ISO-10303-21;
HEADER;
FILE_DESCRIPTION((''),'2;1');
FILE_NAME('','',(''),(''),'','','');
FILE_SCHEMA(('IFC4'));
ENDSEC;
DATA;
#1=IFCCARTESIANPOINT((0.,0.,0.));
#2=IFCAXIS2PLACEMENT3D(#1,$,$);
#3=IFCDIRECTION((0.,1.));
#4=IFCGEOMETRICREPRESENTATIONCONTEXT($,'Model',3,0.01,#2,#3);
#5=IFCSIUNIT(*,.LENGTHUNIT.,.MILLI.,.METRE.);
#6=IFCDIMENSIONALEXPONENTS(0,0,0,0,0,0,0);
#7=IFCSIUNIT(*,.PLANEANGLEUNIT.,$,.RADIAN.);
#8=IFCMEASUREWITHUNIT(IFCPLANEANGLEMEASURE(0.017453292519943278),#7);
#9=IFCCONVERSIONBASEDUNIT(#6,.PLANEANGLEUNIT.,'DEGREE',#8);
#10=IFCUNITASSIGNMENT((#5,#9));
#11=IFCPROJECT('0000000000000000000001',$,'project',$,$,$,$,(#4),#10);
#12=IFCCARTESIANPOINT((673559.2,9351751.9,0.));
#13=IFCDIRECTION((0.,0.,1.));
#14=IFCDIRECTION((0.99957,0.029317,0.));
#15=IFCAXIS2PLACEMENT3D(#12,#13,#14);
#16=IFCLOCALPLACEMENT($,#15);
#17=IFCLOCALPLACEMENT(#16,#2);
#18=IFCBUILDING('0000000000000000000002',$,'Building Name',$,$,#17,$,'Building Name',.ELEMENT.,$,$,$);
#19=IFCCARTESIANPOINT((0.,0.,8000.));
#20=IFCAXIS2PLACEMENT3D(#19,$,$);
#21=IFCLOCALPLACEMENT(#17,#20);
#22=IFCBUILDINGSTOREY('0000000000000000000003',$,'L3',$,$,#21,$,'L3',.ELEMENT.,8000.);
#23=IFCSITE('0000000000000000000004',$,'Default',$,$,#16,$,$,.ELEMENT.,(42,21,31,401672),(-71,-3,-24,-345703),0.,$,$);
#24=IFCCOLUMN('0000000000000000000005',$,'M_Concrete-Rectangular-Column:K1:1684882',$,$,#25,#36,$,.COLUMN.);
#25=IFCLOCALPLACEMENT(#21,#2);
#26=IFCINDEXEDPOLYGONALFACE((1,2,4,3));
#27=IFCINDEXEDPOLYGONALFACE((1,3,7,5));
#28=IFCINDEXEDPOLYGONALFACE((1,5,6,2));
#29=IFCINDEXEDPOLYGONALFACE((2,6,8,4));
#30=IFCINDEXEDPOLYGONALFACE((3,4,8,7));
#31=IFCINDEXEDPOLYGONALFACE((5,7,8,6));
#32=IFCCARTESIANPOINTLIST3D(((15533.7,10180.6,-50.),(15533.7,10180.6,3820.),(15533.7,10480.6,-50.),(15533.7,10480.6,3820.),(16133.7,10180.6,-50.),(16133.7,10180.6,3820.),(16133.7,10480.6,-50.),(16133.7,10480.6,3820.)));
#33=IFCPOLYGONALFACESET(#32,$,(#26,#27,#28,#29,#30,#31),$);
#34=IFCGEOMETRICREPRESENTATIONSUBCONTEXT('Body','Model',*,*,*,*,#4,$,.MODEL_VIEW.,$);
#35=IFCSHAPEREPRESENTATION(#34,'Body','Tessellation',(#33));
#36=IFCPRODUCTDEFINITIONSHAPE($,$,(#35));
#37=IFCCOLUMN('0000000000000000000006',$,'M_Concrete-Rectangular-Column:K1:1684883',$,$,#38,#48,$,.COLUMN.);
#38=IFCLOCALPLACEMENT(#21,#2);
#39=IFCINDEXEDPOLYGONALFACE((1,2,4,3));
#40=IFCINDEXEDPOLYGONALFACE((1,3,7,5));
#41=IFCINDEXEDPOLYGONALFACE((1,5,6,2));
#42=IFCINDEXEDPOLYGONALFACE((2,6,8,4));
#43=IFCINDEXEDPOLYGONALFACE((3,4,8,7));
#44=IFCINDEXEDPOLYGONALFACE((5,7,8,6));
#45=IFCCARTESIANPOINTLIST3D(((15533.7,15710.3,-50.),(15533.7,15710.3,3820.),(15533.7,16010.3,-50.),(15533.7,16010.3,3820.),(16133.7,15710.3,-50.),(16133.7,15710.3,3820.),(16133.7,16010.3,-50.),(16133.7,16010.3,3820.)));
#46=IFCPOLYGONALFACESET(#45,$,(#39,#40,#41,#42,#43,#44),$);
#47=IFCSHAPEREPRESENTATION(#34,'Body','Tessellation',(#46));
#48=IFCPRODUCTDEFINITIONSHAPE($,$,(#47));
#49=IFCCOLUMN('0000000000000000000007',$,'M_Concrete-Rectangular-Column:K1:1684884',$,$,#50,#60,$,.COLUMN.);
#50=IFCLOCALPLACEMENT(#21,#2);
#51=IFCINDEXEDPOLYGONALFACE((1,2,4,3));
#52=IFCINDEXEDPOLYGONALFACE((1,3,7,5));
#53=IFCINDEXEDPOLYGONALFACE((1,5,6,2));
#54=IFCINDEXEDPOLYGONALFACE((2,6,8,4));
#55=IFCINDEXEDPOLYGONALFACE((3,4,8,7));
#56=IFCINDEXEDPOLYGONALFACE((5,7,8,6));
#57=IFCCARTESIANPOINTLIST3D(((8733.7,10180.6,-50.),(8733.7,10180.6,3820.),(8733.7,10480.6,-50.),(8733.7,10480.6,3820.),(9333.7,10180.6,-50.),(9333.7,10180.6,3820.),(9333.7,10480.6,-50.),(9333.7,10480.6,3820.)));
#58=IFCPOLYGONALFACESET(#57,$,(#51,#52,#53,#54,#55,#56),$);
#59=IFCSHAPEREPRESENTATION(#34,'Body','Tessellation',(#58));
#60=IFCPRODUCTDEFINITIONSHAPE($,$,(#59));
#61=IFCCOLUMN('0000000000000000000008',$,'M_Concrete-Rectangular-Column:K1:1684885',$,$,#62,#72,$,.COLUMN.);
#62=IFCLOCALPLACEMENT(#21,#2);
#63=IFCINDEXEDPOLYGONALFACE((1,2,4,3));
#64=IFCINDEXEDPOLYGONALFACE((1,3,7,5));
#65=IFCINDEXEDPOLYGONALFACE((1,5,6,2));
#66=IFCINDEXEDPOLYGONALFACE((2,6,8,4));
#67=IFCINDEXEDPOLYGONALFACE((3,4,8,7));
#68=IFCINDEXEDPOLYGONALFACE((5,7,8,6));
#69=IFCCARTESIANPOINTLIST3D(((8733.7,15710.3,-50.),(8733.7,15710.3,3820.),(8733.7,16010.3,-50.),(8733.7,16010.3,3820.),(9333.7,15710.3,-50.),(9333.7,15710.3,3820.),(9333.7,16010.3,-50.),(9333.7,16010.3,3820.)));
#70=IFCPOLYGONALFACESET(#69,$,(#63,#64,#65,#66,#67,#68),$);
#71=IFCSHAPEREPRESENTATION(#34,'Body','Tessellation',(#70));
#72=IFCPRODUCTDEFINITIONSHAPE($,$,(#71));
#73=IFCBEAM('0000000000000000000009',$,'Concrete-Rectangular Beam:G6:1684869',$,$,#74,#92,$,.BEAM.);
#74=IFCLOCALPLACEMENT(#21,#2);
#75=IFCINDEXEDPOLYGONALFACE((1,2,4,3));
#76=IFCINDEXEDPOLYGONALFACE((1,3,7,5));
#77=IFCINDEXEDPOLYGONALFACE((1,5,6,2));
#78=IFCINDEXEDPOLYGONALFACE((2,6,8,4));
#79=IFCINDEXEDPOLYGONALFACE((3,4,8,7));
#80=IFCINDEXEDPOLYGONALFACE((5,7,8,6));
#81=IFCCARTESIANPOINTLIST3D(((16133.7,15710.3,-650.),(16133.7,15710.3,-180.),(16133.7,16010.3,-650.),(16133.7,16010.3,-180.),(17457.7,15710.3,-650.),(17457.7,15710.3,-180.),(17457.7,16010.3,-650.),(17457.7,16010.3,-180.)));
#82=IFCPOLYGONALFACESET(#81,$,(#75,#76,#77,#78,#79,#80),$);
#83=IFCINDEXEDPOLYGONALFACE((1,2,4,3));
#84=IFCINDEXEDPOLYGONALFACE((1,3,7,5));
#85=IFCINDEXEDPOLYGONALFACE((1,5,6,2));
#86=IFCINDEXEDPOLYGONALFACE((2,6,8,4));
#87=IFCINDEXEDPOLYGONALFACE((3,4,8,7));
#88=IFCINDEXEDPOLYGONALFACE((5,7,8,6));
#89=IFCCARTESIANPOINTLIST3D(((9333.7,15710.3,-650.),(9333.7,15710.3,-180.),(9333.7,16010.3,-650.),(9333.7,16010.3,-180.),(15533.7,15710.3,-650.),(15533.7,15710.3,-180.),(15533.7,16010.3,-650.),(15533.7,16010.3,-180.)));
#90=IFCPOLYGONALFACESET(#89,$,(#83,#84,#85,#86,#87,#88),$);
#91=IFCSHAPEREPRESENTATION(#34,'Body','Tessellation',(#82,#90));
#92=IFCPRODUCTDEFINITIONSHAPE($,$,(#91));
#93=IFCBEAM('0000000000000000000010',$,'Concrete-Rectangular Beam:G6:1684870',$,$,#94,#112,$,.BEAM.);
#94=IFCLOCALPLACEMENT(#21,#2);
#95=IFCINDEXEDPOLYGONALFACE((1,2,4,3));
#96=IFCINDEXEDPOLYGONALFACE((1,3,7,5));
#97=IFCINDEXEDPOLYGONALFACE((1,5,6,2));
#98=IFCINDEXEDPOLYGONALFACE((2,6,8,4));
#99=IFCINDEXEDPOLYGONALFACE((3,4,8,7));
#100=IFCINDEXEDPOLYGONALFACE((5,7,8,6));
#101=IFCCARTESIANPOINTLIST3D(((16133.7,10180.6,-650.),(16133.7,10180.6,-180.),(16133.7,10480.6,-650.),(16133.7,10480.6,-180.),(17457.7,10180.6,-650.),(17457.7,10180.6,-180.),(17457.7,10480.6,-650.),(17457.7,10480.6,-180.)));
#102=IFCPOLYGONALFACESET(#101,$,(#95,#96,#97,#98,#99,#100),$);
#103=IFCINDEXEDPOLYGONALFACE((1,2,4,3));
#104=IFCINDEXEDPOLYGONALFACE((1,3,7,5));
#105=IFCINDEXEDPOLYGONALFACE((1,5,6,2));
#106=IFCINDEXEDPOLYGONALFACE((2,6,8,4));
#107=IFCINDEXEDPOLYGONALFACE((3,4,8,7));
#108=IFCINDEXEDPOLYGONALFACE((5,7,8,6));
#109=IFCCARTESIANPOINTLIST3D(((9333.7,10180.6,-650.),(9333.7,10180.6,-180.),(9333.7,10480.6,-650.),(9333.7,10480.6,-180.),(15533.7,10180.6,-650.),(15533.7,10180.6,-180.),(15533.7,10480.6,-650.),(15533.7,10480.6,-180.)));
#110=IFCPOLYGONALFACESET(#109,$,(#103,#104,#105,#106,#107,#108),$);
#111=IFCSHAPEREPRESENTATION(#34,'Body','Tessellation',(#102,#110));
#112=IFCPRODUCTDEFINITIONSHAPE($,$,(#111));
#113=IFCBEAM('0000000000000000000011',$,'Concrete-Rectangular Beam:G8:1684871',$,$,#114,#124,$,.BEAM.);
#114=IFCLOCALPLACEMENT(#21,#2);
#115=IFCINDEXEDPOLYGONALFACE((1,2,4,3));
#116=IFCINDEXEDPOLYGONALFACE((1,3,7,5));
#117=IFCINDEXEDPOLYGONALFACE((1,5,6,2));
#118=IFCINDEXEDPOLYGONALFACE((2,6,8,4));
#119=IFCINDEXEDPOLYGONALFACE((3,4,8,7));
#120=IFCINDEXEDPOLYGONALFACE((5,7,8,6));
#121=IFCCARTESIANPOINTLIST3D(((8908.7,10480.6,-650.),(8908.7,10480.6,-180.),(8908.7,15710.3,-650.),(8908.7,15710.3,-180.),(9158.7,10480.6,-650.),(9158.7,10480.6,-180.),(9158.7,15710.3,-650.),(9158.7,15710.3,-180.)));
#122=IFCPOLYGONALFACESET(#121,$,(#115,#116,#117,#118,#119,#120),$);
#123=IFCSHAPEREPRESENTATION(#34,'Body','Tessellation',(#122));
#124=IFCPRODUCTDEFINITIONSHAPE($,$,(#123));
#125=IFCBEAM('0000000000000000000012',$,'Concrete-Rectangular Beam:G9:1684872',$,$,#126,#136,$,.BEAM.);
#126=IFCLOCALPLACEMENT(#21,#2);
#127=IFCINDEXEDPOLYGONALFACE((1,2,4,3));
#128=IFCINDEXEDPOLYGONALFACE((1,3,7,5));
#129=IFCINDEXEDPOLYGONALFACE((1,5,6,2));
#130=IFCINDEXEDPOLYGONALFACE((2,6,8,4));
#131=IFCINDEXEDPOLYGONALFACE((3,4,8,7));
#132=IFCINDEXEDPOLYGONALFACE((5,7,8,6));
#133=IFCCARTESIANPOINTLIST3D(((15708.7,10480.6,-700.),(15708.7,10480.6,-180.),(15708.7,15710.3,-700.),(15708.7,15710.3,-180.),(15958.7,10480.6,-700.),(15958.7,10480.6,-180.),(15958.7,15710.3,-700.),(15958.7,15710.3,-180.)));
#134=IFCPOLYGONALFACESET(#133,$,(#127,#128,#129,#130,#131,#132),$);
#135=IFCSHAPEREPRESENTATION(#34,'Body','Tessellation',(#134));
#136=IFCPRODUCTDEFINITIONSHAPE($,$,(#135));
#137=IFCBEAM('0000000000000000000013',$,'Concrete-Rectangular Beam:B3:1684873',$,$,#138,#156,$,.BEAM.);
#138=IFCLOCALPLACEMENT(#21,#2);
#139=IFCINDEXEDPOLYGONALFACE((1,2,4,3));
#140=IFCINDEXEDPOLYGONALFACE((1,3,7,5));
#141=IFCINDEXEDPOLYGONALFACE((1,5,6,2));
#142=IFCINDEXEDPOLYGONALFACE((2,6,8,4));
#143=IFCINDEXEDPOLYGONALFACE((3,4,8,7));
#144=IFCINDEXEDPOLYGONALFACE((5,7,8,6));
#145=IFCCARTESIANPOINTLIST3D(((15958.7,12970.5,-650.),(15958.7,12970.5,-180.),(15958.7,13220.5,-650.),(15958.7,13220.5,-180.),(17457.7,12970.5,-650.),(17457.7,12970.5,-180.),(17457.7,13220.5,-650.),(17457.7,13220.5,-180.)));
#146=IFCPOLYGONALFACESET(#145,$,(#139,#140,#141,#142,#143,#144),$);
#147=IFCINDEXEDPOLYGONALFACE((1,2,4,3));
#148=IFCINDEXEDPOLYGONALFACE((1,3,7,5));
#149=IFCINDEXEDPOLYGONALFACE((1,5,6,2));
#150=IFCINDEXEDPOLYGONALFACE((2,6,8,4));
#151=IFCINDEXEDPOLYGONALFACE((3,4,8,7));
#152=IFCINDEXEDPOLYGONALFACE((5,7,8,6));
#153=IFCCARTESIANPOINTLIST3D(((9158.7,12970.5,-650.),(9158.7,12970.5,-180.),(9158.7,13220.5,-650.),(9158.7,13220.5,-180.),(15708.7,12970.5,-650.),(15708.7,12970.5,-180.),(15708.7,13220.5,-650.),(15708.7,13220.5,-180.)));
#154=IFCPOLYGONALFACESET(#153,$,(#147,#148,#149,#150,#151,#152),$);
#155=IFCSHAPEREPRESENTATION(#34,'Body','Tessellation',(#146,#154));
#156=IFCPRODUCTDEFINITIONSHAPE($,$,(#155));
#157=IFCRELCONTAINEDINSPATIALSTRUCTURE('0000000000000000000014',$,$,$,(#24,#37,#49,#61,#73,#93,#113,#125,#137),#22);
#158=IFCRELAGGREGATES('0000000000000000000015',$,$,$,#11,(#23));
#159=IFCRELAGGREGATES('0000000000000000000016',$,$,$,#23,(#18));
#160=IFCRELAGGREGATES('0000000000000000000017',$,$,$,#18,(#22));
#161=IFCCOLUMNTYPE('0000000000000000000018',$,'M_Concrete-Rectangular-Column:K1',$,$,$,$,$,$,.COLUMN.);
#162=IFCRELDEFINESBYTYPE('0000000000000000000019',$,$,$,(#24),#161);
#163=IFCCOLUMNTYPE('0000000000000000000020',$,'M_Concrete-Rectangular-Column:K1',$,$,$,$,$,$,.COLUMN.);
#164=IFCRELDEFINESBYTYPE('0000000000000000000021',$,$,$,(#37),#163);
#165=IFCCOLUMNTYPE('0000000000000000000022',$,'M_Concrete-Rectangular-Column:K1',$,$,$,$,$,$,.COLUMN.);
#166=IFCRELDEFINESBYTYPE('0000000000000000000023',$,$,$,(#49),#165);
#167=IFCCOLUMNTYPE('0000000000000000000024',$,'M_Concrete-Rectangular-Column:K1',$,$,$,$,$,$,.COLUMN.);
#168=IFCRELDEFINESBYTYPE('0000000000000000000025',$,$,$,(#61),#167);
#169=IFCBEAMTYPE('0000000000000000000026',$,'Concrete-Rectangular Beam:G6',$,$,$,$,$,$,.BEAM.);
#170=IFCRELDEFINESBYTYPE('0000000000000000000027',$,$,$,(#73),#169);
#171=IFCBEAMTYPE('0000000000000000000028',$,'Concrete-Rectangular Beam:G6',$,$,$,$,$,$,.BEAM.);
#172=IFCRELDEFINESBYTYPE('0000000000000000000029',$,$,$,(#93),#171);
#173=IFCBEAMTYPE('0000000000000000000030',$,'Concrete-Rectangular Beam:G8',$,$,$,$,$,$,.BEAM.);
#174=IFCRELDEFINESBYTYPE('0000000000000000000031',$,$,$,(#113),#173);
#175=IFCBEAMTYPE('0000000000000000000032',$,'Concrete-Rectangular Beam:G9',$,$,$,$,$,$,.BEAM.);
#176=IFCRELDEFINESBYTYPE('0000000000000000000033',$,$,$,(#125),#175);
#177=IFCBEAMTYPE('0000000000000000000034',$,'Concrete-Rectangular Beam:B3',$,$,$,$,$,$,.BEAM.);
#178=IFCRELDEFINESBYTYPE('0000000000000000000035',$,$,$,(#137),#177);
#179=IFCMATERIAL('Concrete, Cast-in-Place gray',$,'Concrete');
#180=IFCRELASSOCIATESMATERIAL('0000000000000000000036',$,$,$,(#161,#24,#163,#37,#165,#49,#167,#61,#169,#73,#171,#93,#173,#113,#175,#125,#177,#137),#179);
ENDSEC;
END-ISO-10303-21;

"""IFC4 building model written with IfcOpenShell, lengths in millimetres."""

from ifc_helpers import new_model, entity, si_unit, converted_unit, direction, frame, origin, place, context, subcontext, project, spatial, indexed_curve, outline, extrude, source, transform, mapped, material, type_object, type_shapes, element, save


model = new_model("IFC4")

# Units and contexts
model_context = context("Model", 3, precision=0.01, world=origin(), true_north=direction((0.0, 1.0)))
body_context = subcontext(model_context, "Body", "Model", "MODEL_VIEW")
ifc_project = project(units=[si_unit("LENGTHUNIT", "METRE", prefix="MILLI"), converted_unit("PLANEANGLEUNIT", "DEGREE", entity("IfcPlaneAngleMeasure", 0.017453292519943278), si_unit("PLANEANGLEUNIT", "RADIAN"), dimensions=[0, 0, 0, 0, 0, 0, 0])], contexts=[model_context])

# Site, building, storey
site_placement = place(None, frame((673559.2, 9351751.9, 0.0), z_axis=(0.0, 0.0, 1.0), x_axis=(0.99957, 0.029317, 0.0)))
site = spatial("IfcSite", under=ifc_project, at=site_placement, Name="Default", CompositionType="ELEMENT", RefLatitude=(42, 21, 31, 401672), RefLongitude=(-71, -3, -24, -345703), RefElevation=0.0)
building_placement = place(site_placement, origin())
building = spatial("IfcBuilding", under=site, at=building_placement, Name="Building Name", LongName="Building Name", CompositionType="ELEMENT")
storey_placement = place(building_placement, frame((0.0, 0.0, 8000.0)))
storey = spatial("IfcBuildingStorey", under=building, at=storey_placement, Name="L3", LongName="L3", CompositionType="ELEMENT", Elevation=8000.0)

# Columns
ifc_material = material(Name="Concrete, Cast-in-Place gray", Category="Concrete")
column_type_1 = type_object("IfcColumnType", Name="M_Concrete-Rectangular-Column:K1", PredefinedType="COLUMN", material=ifc_material)
shared_shape_1 = source(origin(), body_context, "Body", "SweptSolid", [
    extrude(outline(indexed_curve([(-150.0, -300.0), (150.0, -300.0), (150.0, 300.0), (-150.0, 300.0), (-150.0, -300.0)], self_intersect=False)), frame((15833.7, 10330.6, 7950.0), z_axis=(0.0, 0.0, 1.0), x_axis=(0.0, -1.0, 0.0)), (0.0, 0.0, 1.0), 3870.0),
])
type_shapes(column_type_1, [shared_shape_1])
column_1_placement = place(storey_placement, frame((0.0, 0.0, -8000.0)))
element("IfcColumn", 1, at=column_1_placement, inside=storey, type_object=column_type_1, material=ifc_material, Name="M_Concrete-Rectangular-Column:K1:1684882", PredefinedType="COLUMN", context=body_context, shape_type="MappedRepresentation", body=[
    mapped(shared_shape_1, transform((0.0, 0.0, 0.0), scale=1.0)),
])
column_type_2 = type_object("IfcColumnType", Name="M_Concrete-Rectangular-Column:K1", PredefinedType="COLUMN", material=ifc_material)
shared_shape_2 = source(origin(), body_context, "Body", "SweptSolid", [
    extrude(outline(indexed_curve([(-150.0, -300.0), (150.0, -300.0), (150.0, 300.0), (-150.0, 300.0), (-150.0, -300.0)], self_intersect=False)), frame((15833.7, 15860.3, 7950.0), z_axis=(0.0, 0.0, 1.0), x_axis=(0.0, -1.0, 0.0)), (0.0, 0.0, 1.0), 3870.0),
])
type_shapes(column_type_2, [shared_shape_2])
column_2_placement = place(storey_placement, frame((0.0, 0.0, -8000.0)))
element("IfcColumn", 2, at=column_2_placement, inside=storey, type_object=column_type_2, material=ifc_material, Name="M_Concrete-Rectangular-Column:K1:1684883", PredefinedType="COLUMN", context=body_context, shape_type="MappedRepresentation", body=[
    mapped(shared_shape_2, transform((0.0, 0.0, 0.0), scale=1.0)),
])
column_type_3 = type_object("IfcColumnType", Name="M_Concrete-Rectangular-Column:K1", PredefinedType="COLUMN", material=ifc_material)
shared_shape_3 = source(origin(), body_context, "Body", "SweptSolid", [
    extrude(outline(indexed_curve([(-150.0, -300.0), (150.0, -300.0), (150.0, 300.0), (-150.0, 300.0), (-150.0, -300.0)], self_intersect=False)), frame((9033.7, 10330.6, 7950.0), z_axis=(0.0, 0.0, 1.0), x_axis=(0.0, -1.0, 0.0)), (0.0, 0.0, 1.0), 3870.0),
])
type_shapes(column_type_3, [shared_shape_3])
column_3_placement = place(storey_placement, frame((0.0, 0.0, -8000.0)))
element("IfcColumn", 3, at=column_3_placement, inside=storey, type_object=column_type_3, material=ifc_material, Name="M_Concrete-Rectangular-Column:K1:1684884", PredefinedType="COLUMN", context=body_context, shape_type="MappedRepresentation", body=[
    mapped(shared_shape_3, transform((0.0, 0.0, 0.0), scale=1.0)),
])
column_type_4 = type_object("IfcColumnType", Name="M_Concrete-Rectangular-Column:K1", PredefinedType="COLUMN", material=ifc_material)
shared_shape_4 = source(origin(), body_context, "Body", "SweptSolid", [
    extrude(outline(indexed_curve([(-150.0, -300.0), (150.0, -300.0), (150.0, 300.0), (-150.0, 300.0), (-150.0, -300.0)], self_intersect=False)), frame((9033.7, 15860.3, 7950.0), z_axis=(0.0, 0.0, 1.0), x_axis=(0.0, -1.0, 0.0)), (0.0, 0.0, 1.0), 3870.0),
])
type_shapes(column_type_4, [shared_shape_4])
column_4_placement = place(storey_placement, frame((0.0, 0.0, -8000.0)))
element("IfcColumn", 4, at=column_4_placement, inside=storey, type_object=column_type_4, material=ifc_material, Name="M_Concrete-Rectangular-Column:K1:1684885", PredefinedType="COLUMN", context=body_context, shape_type="MappedRepresentation", body=[
    mapped(shared_shape_4, transform((0.0, 0.0, 0.0), scale=1.0)),
])

# Beams
beam_type_1 = type_object("IfcBeamType", Name="Concrete-Rectangular Beam:G6", PredefinedType="BEAM", material=ifc_material)
shared_shape_5 = source(origin(), body_context, "Body", "SweptSolid", [
    extrude(outline(indexed_curve([(-235.0, -150.0), (235.0, -150.0), (235.0, 150.0), (-235.0, 150.0), (-235.0, -150.0)], self_intersect=False)), frame((16133.7, 15860.3, 7585.0), z_axis=(1.0, 0.0, 0.0), x_axis=(0.0, 0.0, -1.0)), (0.0, 0.0, 1.0), 1324.0),
    extrude(outline(indexed_curve([(-235.0, -150.0), (235.0, -150.0), (235.0, 150.0), (-235.0, 150.0), (-235.0, -150.0)], self_intersect=False)), frame((9333.7, 15860.3, 7585.0), z_axis=(1.0, 0.0, 0.0), x_axis=(0.0, 0.0, -1.0)), (0.0, 0.0, 1.0), 6200.0),
])
type_shapes(beam_type_1, [shared_shape_5])
beam_1_placement = place(storey_placement, frame((0.0, 0.0, -8000.0)))
element("IfcBeam", 5, at=beam_1_placement, inside=storey, type_object=beam_type_1, material=ifc_material, Name="Concrete-Rectangular Beam:G6:1684869", PredefinedType="BEAM", context=body_context, shape_type="MappedRepresentation", body=[
    mapped(shared_shape_5, transform((0.0, 0.0, 0.0), scale=1.0)),
])
beam_type_2 = type_object("IfcBeamType", Name="Concrete-Rectangular Beam:G6", PredefinedType="BEAM", material=ifc_material)
shared_shape_6 = source(origin(), body_context, "Body", "SweptSolid", [
    extrude(outline(indexed_curve([(-235.0, -150.0), (235.0, -150.0), (235.0, 150.0), (-235.0, 150.0), (-235.0, -150.0)], self_intersect=False)), frame((16133.7, 10330.6, 7585.0), z_axis=(1.0, 0.0, 0.0), x_axis=(0.0, 0.0, -1.0)), (0.0, 0.0, 1.0), 1324.0),
    extrude(outline(indexed_curve([(-235.0, -150.0), (235.0, -150.0), (235.0, 150.0), (-235.0, 150.0), (-235.0, -150.0)], self_intersect=False)), frame((9333.7, 10330.6, 7585.0), z_axis=(1.0, 0.0, 0.0), x_axis=(0.0, 0.0, -1.0)), (0.0, 0.0, 1.0), 6200.0),
])
type_shapes(beam_type_2, [shared_shape_6])
beam_2_placement = place(storey_placement, frame((0.0, 0.0, -8000.0)))
element("IfcBeam", 6, at=beam_2_placement, inside=storey, type_object=beam_type_2, material=ifc_material, Name="Concrete-Rectangular Beam:G6:1684870", PredefinedType="BEAM", context=body_context, shape_type="MappedRepresentation", body=[
    mapped(shared_shape_6, transform((0.0, 0.0, 0.0), scale=1.0)),
])
beam_type_3 = type_object("IfcBeamType", Name="Concrete-Rectangular Beam:G8", PredefinedType="BEAM", material=ifc_material)
shared_shape_7 = source(origin(), body_context, "Body", "SweptSolid", [
    extrude(outline(indexed_curve([(-125.0, -235.0), (125.0, -235.0), (125.0, 235.0), (-125.0, 235.0), (-125.0, -235.0)], self_intersect=False)), frame((9033.7, 15710.3, 7585.0), z_axis=(0.0, -1.0, 0.0), x_axis=(-1.0, 0.0, 0.0)), (0.0, 0.0, 1.0), 5229.7),
])
type_shapes(beam_type_3, [shared_shape_7])
beam_3_placement = place(storey_placement, frame((0.0, 0.0, -8000.0)))
element("IfcBeam", 7, at=beam_3_placement, inside=storey, type_object=beam_type_3, material=ifc_material, Name="Concrete-Rectangular Beam:G8:1684871", PredefinedType="BEAM", context=body_context, shape_type="MappedRepresentation", body=[
    mapped(shared_shape_7, transform((0.0, 0.0, 0.0), scale=1.0)),
])
beam_type_4 = type_object("IfcBeamType", Name="Concrete-Rectangular Beam:G9", PredefinedType="BEAM", material=ifc_material)
shared_shape_8 = source(origin(), body_context, "Body", "SweptSolid", [
    extrude(outline(indexed_curve([(-125.0, -260.0), (125.0, -260.0), (125.0, 260.0), (-125.0, 260.0), (-125.0, -260.0)], self_intersect=False)), frame((15833.7, 15710.3, 7560.0), z_axis=(0.0, -1.0, 0.0), x_axis=(-1.0, 0.0, 0.0)), (0.0, 0.0, 1.0), 5229.7),
])
type_shapes(beam_type_4, [shared_shape_8])
beam_4_placement = place(storey_placement, frame((0.0, 0.0, -8000.0)))
element("IfcBeam", 8, at=beam_4_placement, inside=storey, type_object=beam_type_4, material=ifc_material, Name="Concrete-Rectangular Beam:G9:1684872", PredefinedType="BEAM", context=body_context, shape_type="MappedRepresentation", body=[
    mapped(shared_shape_8, transform((0.0, 0.0, 0.0), scale=1.0)),
])
beam_type_5 = type_object("IfcBeamType", Name="Concrete-Rectangular Beam:B3", PredefinedType="BEAM", material=ifc_material)
shared_shape_9 = source(origin(), body_context, "Body", "SweptSolid", [
    extrude(outline(indexed_curve([(-235.0, -125.0), (235.0, -125.0), (235.0, 125.0), (-235.0, 125.0), (-235.0, -125.0)], self_intersect=False)), frame((15958.7, 13095.5, 7585.0), z_axis=(1.0, 0.0, 0.0), x_axis=(0.0, 0.0, -1.0)), (0.0, 0.0, 1.0), 1499.0),
    extrude(outline(indexed_curve([(-235.0, -125.0), (235.0, -125.0), (235.0, 125.0), (-235.0, 125.0), (-235.0, -125.0)], self_intersect=False)), frame((9158.7, 13095.5, 7585.0), z_axis=(1.0, 0.0, 0.0), x_axis=(0.0, 0.0, -1.0)), (0.0, 0.0, 1.0), 6550.0),
])
type_shapes(beam_type_5, [shared_shape_9])
beam_5_placement = place(storey_placement, frame((0.0, 0.0, -8000.0)))
element("IfcBeam", 9, at=beam_5_placement, inside=storey, type_object=beam_type_5, material=ifc_material, Name="Concrete-Rectangular Beam:B3:1684873", PredefinedType="BEAM", context=body_context, shape_type="MappedRepresentation", body=[
    mapped(shared_shape_9, transform((0.0, 0.0, 0.0), scale=1.0)),
])

save(model, "model.ifc")
